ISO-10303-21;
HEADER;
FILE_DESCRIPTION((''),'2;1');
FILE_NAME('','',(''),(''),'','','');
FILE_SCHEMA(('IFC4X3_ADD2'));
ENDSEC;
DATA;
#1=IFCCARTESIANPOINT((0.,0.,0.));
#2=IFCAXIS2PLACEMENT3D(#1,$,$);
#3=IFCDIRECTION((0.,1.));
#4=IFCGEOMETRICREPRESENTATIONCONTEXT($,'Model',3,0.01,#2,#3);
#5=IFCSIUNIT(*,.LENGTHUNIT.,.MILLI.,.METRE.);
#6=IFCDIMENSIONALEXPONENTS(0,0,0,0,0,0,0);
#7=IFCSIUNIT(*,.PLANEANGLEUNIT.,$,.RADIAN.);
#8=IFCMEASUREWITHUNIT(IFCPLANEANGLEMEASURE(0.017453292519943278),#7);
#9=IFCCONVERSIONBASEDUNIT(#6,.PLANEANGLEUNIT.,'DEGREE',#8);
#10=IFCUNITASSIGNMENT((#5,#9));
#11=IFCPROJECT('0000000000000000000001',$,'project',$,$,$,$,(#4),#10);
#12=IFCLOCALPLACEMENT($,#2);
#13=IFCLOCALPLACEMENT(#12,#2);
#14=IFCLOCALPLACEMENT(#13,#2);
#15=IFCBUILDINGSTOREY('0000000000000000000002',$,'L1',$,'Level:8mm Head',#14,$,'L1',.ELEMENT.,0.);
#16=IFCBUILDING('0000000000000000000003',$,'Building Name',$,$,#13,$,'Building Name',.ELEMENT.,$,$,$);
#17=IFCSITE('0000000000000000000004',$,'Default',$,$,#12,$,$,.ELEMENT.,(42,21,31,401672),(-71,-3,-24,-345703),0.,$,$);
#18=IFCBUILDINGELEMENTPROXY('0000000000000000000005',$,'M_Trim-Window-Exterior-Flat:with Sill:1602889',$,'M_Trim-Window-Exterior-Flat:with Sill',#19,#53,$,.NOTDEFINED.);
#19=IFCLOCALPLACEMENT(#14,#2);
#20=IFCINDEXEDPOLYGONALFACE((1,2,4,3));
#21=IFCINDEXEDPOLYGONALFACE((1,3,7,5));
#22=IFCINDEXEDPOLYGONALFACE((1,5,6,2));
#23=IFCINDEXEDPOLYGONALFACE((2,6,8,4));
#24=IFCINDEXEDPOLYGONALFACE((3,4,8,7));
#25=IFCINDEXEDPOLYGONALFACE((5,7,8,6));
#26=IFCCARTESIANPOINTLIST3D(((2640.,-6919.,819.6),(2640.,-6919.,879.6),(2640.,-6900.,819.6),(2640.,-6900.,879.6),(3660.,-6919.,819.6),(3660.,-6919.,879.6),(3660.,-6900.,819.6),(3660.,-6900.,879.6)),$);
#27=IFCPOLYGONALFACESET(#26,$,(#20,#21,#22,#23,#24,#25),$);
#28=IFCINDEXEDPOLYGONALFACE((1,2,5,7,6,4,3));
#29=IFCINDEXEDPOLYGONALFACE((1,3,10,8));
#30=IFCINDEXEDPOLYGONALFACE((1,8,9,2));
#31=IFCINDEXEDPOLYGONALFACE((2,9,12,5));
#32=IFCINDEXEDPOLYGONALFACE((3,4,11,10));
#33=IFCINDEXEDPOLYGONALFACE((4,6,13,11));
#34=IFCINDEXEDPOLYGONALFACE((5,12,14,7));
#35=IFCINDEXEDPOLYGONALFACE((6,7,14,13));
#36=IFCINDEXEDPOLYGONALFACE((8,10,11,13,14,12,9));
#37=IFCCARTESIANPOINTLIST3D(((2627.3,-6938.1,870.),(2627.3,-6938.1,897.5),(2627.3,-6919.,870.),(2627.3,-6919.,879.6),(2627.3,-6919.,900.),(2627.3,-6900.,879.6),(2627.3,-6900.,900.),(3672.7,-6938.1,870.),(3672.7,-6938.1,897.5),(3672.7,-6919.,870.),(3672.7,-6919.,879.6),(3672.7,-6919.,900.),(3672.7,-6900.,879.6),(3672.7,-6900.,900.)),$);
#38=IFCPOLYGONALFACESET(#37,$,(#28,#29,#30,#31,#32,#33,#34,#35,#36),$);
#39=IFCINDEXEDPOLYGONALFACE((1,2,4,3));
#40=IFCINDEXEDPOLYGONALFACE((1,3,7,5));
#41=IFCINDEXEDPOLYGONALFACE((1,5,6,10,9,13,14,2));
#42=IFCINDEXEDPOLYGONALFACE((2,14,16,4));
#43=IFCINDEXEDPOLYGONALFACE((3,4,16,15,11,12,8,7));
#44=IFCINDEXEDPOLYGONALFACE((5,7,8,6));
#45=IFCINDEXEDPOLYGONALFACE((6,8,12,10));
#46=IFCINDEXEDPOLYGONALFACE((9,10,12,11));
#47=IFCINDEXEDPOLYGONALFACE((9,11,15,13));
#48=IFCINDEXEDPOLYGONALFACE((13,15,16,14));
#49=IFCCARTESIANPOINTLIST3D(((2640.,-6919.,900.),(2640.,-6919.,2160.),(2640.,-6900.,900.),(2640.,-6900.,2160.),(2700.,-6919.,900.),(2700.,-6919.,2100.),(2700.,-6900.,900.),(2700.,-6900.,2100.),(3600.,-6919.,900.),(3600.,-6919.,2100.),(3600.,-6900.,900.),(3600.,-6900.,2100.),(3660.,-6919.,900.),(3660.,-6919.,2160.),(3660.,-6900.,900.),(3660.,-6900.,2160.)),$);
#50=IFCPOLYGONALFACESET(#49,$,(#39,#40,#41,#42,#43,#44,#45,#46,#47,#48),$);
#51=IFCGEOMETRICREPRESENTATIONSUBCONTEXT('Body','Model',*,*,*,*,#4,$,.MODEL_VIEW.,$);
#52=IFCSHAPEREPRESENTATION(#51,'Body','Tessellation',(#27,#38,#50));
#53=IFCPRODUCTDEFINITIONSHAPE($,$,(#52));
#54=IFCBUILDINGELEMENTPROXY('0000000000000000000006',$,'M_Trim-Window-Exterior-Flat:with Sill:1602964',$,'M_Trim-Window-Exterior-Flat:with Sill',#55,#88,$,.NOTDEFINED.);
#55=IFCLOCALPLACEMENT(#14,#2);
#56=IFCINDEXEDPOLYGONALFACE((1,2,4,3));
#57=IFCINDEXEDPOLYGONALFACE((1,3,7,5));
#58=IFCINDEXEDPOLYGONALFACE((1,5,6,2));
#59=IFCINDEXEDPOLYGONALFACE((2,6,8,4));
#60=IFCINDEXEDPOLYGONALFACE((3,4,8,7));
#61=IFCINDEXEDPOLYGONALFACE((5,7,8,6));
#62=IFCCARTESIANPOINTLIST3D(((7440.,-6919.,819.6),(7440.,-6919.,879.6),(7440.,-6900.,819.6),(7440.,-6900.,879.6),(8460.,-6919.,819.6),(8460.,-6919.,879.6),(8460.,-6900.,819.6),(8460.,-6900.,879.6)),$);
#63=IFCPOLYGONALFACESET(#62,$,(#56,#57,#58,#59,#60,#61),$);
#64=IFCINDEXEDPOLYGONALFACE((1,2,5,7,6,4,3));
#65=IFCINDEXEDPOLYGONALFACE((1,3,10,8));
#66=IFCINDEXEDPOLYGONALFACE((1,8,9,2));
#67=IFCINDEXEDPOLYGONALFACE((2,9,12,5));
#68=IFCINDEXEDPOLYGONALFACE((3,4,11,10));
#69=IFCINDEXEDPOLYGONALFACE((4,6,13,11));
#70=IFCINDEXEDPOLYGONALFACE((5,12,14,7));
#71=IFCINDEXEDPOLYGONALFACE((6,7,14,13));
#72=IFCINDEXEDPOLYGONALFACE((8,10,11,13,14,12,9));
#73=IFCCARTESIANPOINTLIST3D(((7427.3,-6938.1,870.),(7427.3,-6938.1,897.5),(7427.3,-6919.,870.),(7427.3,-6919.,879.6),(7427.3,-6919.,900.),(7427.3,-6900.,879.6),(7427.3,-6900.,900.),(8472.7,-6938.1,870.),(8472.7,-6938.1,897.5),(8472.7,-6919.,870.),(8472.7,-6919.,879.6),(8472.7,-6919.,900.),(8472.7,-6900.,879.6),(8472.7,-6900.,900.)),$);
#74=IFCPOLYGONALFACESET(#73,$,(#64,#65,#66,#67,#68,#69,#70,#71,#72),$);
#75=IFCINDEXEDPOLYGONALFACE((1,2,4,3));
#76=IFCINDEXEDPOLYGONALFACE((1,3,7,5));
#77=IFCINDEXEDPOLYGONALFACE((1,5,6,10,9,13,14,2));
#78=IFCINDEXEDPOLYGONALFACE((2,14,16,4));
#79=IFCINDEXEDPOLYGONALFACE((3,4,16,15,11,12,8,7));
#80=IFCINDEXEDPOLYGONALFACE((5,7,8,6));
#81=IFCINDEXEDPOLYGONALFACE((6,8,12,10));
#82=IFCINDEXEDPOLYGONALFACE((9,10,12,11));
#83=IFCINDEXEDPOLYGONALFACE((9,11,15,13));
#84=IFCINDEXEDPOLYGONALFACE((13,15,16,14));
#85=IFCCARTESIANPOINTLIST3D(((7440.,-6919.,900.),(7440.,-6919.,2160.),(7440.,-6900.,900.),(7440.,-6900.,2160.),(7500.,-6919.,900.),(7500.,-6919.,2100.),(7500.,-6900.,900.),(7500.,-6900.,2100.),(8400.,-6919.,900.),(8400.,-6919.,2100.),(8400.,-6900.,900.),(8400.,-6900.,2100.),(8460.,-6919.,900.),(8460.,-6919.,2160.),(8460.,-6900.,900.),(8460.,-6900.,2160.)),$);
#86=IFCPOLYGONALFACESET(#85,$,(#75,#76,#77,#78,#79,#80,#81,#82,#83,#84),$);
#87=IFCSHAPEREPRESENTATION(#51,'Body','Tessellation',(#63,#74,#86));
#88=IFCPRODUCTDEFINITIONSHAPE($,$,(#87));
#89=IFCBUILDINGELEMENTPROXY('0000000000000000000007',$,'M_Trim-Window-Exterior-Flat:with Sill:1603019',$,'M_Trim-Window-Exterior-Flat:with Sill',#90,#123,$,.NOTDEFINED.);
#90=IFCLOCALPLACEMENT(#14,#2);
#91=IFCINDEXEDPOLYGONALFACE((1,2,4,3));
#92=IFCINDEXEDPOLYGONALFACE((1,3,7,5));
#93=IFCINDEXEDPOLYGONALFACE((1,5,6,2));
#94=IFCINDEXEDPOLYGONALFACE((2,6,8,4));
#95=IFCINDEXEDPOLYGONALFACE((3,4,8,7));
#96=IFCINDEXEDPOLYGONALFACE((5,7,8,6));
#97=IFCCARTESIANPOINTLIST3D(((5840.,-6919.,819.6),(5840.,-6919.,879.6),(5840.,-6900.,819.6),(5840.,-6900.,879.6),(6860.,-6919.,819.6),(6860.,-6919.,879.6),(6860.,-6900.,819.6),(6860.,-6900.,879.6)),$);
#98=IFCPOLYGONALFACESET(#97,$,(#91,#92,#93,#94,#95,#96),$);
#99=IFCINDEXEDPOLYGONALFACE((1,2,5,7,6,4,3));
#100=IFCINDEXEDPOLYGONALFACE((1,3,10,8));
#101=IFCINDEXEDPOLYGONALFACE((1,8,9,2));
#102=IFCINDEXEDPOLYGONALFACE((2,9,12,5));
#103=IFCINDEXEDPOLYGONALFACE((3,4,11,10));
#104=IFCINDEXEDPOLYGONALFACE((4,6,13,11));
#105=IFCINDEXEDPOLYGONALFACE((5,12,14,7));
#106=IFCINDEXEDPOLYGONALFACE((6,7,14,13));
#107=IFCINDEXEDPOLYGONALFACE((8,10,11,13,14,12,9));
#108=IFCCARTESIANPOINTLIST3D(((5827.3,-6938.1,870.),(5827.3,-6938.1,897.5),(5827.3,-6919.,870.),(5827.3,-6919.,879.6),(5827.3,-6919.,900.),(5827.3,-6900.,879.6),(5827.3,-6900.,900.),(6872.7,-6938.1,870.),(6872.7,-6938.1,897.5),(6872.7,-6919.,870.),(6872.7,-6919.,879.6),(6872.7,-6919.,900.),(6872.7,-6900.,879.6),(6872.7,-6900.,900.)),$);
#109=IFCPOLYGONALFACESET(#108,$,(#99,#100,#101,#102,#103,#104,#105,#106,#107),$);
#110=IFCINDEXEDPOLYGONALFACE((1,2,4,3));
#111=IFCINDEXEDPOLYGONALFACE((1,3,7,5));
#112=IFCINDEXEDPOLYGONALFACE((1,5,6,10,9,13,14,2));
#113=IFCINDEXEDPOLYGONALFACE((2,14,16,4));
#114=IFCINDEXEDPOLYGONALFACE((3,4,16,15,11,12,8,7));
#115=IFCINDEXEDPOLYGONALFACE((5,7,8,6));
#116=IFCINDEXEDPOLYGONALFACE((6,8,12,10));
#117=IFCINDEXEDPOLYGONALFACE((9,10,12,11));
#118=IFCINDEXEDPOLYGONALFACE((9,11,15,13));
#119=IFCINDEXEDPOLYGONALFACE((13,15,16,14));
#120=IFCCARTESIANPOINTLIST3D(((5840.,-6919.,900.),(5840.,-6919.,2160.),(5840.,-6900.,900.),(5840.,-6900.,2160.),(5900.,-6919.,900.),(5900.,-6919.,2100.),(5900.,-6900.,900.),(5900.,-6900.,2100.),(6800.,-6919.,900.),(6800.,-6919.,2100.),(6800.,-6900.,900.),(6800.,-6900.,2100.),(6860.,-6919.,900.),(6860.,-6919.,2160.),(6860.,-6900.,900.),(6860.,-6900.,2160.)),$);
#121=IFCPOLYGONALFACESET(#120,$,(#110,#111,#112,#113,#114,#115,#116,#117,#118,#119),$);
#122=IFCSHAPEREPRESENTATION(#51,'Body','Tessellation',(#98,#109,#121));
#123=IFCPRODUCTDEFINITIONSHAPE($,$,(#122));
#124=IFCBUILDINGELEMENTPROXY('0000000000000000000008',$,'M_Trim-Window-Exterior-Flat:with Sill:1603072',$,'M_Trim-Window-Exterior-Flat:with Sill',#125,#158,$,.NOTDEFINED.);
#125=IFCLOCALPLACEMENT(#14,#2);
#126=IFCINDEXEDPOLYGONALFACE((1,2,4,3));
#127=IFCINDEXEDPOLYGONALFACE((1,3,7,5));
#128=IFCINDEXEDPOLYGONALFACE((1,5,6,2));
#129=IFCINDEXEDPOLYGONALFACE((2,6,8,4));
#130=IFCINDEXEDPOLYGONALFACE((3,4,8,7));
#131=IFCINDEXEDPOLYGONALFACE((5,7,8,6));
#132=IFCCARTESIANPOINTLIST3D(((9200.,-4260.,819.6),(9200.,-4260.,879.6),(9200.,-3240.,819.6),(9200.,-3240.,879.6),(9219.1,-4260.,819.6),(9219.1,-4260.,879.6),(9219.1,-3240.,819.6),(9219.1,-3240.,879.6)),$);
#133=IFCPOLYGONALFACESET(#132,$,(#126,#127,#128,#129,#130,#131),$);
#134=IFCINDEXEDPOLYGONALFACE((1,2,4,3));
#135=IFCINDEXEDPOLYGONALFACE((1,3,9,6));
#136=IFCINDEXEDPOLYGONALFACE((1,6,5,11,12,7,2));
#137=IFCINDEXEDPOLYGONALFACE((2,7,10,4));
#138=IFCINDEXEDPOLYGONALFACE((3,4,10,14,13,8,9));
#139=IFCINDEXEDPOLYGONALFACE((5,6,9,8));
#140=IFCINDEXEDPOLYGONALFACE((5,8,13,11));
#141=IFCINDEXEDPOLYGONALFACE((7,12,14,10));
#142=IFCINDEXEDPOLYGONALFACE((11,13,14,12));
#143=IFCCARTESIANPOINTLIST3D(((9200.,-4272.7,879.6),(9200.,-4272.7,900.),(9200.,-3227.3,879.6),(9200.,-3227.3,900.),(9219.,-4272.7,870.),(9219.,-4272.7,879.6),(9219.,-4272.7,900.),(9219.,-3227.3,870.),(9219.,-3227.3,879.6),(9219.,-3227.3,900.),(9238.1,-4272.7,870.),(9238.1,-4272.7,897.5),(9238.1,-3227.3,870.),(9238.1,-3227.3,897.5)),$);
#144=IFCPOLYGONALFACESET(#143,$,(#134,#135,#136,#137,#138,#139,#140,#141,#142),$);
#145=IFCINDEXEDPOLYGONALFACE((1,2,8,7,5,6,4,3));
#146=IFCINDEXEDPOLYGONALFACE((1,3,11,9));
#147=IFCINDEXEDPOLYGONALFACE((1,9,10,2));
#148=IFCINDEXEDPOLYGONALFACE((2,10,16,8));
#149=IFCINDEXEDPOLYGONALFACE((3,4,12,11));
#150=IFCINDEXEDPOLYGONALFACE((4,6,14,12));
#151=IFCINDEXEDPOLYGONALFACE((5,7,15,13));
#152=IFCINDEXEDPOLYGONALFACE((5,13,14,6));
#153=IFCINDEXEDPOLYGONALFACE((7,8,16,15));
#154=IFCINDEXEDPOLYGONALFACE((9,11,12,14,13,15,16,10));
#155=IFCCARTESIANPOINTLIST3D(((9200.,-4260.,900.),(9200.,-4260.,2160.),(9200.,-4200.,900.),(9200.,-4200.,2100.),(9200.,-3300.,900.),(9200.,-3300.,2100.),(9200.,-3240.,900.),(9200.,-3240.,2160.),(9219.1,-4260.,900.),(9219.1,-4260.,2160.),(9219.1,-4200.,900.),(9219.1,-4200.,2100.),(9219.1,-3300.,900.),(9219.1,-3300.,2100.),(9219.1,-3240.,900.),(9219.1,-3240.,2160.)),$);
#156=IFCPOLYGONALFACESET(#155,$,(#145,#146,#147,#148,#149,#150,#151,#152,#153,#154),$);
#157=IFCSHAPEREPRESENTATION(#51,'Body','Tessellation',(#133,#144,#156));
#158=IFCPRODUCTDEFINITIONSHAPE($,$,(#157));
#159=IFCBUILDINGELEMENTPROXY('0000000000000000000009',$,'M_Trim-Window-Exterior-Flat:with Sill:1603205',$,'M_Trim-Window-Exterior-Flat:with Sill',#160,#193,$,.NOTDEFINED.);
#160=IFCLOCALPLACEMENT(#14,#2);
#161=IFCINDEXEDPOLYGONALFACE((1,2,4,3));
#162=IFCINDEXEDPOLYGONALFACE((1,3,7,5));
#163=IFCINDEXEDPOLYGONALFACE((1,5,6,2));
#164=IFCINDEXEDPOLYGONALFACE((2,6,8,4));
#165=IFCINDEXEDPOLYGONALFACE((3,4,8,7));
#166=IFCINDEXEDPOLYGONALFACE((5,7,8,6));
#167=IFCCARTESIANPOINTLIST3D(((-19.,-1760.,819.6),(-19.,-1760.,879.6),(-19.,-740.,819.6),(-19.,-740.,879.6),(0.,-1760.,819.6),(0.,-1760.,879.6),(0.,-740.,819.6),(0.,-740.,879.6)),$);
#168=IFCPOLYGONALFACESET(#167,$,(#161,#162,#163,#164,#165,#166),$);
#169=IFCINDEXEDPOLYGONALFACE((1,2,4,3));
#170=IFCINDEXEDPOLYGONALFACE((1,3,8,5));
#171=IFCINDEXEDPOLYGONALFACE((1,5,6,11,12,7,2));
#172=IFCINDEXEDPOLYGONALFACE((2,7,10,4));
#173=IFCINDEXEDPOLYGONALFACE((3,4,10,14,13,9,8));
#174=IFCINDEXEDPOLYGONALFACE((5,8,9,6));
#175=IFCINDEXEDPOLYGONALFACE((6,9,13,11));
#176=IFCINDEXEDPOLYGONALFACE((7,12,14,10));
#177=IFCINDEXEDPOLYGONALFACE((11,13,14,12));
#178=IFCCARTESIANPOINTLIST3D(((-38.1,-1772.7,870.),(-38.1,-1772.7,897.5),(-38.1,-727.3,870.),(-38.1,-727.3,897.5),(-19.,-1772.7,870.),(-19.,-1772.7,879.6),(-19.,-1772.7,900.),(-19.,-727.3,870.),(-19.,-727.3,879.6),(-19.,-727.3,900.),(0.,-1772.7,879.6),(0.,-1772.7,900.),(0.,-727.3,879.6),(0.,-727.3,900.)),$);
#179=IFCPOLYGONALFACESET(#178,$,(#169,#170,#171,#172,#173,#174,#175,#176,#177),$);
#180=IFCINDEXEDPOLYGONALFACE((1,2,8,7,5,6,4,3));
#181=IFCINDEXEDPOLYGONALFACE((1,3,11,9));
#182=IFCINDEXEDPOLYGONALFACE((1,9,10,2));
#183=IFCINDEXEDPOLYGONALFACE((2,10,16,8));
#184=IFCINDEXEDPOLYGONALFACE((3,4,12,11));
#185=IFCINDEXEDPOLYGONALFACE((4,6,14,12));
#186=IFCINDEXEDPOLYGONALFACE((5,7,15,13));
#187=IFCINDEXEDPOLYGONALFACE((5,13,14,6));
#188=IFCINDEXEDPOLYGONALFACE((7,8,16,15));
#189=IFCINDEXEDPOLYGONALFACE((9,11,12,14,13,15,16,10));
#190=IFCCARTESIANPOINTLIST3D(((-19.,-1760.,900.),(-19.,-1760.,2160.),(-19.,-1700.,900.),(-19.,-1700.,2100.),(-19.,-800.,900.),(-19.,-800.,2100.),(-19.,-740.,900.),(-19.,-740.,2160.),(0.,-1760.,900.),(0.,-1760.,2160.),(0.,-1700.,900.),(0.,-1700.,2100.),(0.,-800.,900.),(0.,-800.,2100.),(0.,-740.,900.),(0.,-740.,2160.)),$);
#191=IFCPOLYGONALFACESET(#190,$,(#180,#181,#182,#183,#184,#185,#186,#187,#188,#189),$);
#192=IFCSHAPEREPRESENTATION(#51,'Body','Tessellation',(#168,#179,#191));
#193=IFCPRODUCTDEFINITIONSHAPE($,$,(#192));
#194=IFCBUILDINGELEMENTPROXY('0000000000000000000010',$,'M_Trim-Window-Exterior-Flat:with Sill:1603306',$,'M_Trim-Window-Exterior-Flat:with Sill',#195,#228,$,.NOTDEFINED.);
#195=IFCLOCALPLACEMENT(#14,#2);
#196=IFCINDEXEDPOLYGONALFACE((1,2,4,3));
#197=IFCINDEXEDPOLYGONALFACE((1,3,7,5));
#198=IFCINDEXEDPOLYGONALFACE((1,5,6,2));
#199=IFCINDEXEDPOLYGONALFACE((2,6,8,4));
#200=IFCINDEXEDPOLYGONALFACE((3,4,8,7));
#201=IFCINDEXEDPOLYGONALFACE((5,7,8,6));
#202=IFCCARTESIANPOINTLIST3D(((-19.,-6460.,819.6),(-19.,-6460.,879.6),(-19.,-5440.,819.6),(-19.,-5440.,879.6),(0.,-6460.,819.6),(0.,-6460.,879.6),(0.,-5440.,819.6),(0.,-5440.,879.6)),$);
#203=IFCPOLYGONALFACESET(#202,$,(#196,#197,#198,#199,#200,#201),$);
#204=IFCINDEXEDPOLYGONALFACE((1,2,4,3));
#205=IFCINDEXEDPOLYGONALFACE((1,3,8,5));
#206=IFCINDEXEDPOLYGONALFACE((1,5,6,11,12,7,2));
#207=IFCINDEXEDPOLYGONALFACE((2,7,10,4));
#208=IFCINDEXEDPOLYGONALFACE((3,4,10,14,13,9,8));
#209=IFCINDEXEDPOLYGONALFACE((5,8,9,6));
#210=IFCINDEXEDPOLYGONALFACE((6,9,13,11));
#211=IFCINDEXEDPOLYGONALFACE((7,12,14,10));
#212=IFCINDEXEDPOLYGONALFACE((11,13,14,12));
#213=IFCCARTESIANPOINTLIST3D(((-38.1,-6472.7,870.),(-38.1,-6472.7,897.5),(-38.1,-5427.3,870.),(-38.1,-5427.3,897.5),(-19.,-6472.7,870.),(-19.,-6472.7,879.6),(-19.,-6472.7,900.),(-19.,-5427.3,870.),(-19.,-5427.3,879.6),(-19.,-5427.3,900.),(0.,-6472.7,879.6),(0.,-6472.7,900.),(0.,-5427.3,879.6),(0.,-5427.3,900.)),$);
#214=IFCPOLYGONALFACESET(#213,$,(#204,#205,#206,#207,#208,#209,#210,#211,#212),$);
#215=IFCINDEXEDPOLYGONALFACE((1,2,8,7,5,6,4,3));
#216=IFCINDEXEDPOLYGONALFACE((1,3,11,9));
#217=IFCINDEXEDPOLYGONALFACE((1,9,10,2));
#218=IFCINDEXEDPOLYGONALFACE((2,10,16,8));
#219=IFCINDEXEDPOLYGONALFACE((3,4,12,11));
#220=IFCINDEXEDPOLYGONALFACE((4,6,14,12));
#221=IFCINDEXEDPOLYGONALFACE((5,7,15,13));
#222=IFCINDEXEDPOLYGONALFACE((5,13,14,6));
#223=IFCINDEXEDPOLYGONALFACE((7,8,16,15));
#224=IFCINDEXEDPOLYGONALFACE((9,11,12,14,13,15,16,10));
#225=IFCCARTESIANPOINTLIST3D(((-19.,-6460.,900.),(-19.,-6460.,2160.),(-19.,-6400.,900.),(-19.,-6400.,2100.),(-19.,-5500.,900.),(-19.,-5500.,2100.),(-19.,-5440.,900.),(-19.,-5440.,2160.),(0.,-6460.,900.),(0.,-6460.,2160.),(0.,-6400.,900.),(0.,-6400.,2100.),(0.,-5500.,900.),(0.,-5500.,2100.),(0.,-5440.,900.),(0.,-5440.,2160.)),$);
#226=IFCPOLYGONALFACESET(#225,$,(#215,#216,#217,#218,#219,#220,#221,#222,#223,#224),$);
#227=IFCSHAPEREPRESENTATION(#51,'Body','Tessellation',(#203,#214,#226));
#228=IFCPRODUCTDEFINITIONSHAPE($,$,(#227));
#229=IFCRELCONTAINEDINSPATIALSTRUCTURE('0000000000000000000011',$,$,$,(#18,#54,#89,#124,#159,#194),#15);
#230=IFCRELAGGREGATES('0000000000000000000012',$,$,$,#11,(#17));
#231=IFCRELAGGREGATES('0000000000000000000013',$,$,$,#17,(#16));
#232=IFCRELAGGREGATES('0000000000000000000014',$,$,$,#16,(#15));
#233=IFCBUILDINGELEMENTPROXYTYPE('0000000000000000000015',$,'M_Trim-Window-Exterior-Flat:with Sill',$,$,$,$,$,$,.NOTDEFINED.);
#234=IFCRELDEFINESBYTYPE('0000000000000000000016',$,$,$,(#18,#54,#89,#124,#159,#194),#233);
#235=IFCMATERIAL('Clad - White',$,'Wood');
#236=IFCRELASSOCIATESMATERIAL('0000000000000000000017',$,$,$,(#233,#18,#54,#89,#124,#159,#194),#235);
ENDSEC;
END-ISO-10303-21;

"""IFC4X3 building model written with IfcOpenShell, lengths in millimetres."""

from ifc_helpers import new_model, entity, si_unit, converted_unit, direction, frame, frame_2d, origin, place, context, subcontext, project, spatial, polyline, rectangle, outline, extrude, source, transform, mapped, material, type_object, type_shapes, element, save


model = new_model("IFC4X3")

# Units and contexts
model_context = context("Model", 3, precision=0.01, world=origin(), true_north=direction((0.0, 1.0)))
body_context = subcontext(model_context, "Body", "Model", "MODEL_VIEW")
ifc_project = project(units=[si_unit("LENGTHUNIT", "METRE", prefix="MILLI"), converted_unit("PLANEANGLEUNIT", "DEGREE", entity("IfcPlaneAngleMeasure", 0.017453292519943278), si_unit("PLANEANGLEUNIT", "RADIAN"), dimensions=[0, 0, 0, 0, 0, 0, 0])], contexts=[model_context])

# Site, building, storey
site_placement = place(None, origin())
site = spatial("IfcSite", under=ifc_project, at=site_placement, Name="Default", CompositionType="ELEMENT", RefLatitude=(42, 21, 31, 401672), RefLongitude=(-71, -3, -24, -345703), RefElevation=0.0)
building_placement = place(site_placement, origin())
building = spatial("IfcBuilding", under=site, at=building_placement, Name="Building Name", LongName="Building Name", CompositionType="ELEMENT")
storey_placement = place(building_placement, origin())
storey = spatial("IfcBuildingStorey", under=building, at=storey_placement, Name="L1", ObjectType="Level:8mm Head", LongName="L1", CompositionType="ELEMENT", Elevation=0.0)

# Building element proxies
ifc_material_1 = material(Name="Clad - White", Category="Wood")
building_element_proxy_type_1 = type_object("IfcBuildingElementProxyType", Name="M_Trim-Window-Exterior-Flat:with Sill", PredefinedType="NOTDEFINED", material=ifc_material_1)
shared_shape_1 = source(origin(), body_context, "Body", "SweptSolid", [
    extrude(rectangle(XDim=1020.0, YDim=60.0, at=frame_2d((0.0, 0.0), x_axis=(1.0, 0.0))), frame((0.0, -1250.4, 0.0), z_axis=(0.0, 0.0, 1.0), x_axis=(-1.0, 0.0, 0.0)), (0.0, 0.0, 1.0), 19.0),
    extrude(outline(polyline([(-19.0, -15.2), (0.0, -15.2), (0.0, -5.7), (19.0, -5.7), (19.0, 14.8), (0.0, 14.8), (-19.0, 12.3), (-19.0, -15.2)])), frame((-522.7, -1214.8, 19.0), z_axis=(1.0, 0.0, 0.0), x_axis=(0.0, 0.0, -1.0)), (0.0, 0.0, 1.0), 1045.4),
    extrude(outline(polyline([(-645.0, -510.0), (615.0, -510.0), (615.0, -450.0), (-585.0, -450.0), (-585.0, 450.0), (615.0, 450.0), (615.0, 510.0), (-645.0, 510.0), (-645.0, -510.0)])), frame((0.0, -585.0, 0.0), z_axis=(0.0, 0.0, 1.0), x_axis=(0.0, -1.0, 0.0)), (0.0, 0.0, 1.0), 19.0),
])
type_shapes(building_element_proxy_type_1, [shared_shape_1])
for number, where, z_axis, x_axis, name in (
    (1, (3150.0, -6900.0, 2100.0), (0.0, -1.0, 0.0), (1.0, 0.0, 0.0), "M_Trim-Window-Exterior-Flat:with Sill:1602889"),
    (2, (7950.0, -6900.0, 2100.0), (0.0, -1.0, 0.0), (1.0, 0.0, 0.0), "M_Trim-Window-Exterior-Flat:with Sill:1602964"),
    (3, (6350.0, -6900.0, 2100.0), (0.0, -1.0, 0.0), (1.0, 0.0, 0.0), "M_Trim-Window-Exterior-Flat:with Sill:1603019"),
    (4, (9200.0, -3750.0, 2100.0), (1.0, 0.0, 0.0), (0.0, 1.0, 0.0), "M_Trim-Window-Exterior-Flat:with Sill:1603072"),
    (5, (0.0, -1250.0, 2100.0), (-1.0, 0.0, 0.0), (0.0, -1.0, 0.0), "M_Trim-Window-Exterior-Flat:with Sill:1603205"),
    (6, (0.0, -5950.0, 2100.0), (-1.0, 0.0, 0.0), (0.0, -1.0, 0.0), "M_Trim-Window-Exterior-Flat:with Sill:1603306"),
):
    element("IfcBuildingElementProxy", number, at=place(storey_placement, frame(where, z_axis=z_axis, x_axis=x_axis)), inside=storey, type_object=building_element_proxy_type_1, material=ifc_material_1, Name=name, ObjectType="M_Trim-Window-Exterior-Flat:with Sill", PredefinedType="NOTDEFINED", context=body_context, shape_type="MappedRepresentation", body=[
        mapped(shared_shape_1, transform((0.0, 0.0, 0.0), scale=1.0)),
    ])

save(model, "model.ifc")
